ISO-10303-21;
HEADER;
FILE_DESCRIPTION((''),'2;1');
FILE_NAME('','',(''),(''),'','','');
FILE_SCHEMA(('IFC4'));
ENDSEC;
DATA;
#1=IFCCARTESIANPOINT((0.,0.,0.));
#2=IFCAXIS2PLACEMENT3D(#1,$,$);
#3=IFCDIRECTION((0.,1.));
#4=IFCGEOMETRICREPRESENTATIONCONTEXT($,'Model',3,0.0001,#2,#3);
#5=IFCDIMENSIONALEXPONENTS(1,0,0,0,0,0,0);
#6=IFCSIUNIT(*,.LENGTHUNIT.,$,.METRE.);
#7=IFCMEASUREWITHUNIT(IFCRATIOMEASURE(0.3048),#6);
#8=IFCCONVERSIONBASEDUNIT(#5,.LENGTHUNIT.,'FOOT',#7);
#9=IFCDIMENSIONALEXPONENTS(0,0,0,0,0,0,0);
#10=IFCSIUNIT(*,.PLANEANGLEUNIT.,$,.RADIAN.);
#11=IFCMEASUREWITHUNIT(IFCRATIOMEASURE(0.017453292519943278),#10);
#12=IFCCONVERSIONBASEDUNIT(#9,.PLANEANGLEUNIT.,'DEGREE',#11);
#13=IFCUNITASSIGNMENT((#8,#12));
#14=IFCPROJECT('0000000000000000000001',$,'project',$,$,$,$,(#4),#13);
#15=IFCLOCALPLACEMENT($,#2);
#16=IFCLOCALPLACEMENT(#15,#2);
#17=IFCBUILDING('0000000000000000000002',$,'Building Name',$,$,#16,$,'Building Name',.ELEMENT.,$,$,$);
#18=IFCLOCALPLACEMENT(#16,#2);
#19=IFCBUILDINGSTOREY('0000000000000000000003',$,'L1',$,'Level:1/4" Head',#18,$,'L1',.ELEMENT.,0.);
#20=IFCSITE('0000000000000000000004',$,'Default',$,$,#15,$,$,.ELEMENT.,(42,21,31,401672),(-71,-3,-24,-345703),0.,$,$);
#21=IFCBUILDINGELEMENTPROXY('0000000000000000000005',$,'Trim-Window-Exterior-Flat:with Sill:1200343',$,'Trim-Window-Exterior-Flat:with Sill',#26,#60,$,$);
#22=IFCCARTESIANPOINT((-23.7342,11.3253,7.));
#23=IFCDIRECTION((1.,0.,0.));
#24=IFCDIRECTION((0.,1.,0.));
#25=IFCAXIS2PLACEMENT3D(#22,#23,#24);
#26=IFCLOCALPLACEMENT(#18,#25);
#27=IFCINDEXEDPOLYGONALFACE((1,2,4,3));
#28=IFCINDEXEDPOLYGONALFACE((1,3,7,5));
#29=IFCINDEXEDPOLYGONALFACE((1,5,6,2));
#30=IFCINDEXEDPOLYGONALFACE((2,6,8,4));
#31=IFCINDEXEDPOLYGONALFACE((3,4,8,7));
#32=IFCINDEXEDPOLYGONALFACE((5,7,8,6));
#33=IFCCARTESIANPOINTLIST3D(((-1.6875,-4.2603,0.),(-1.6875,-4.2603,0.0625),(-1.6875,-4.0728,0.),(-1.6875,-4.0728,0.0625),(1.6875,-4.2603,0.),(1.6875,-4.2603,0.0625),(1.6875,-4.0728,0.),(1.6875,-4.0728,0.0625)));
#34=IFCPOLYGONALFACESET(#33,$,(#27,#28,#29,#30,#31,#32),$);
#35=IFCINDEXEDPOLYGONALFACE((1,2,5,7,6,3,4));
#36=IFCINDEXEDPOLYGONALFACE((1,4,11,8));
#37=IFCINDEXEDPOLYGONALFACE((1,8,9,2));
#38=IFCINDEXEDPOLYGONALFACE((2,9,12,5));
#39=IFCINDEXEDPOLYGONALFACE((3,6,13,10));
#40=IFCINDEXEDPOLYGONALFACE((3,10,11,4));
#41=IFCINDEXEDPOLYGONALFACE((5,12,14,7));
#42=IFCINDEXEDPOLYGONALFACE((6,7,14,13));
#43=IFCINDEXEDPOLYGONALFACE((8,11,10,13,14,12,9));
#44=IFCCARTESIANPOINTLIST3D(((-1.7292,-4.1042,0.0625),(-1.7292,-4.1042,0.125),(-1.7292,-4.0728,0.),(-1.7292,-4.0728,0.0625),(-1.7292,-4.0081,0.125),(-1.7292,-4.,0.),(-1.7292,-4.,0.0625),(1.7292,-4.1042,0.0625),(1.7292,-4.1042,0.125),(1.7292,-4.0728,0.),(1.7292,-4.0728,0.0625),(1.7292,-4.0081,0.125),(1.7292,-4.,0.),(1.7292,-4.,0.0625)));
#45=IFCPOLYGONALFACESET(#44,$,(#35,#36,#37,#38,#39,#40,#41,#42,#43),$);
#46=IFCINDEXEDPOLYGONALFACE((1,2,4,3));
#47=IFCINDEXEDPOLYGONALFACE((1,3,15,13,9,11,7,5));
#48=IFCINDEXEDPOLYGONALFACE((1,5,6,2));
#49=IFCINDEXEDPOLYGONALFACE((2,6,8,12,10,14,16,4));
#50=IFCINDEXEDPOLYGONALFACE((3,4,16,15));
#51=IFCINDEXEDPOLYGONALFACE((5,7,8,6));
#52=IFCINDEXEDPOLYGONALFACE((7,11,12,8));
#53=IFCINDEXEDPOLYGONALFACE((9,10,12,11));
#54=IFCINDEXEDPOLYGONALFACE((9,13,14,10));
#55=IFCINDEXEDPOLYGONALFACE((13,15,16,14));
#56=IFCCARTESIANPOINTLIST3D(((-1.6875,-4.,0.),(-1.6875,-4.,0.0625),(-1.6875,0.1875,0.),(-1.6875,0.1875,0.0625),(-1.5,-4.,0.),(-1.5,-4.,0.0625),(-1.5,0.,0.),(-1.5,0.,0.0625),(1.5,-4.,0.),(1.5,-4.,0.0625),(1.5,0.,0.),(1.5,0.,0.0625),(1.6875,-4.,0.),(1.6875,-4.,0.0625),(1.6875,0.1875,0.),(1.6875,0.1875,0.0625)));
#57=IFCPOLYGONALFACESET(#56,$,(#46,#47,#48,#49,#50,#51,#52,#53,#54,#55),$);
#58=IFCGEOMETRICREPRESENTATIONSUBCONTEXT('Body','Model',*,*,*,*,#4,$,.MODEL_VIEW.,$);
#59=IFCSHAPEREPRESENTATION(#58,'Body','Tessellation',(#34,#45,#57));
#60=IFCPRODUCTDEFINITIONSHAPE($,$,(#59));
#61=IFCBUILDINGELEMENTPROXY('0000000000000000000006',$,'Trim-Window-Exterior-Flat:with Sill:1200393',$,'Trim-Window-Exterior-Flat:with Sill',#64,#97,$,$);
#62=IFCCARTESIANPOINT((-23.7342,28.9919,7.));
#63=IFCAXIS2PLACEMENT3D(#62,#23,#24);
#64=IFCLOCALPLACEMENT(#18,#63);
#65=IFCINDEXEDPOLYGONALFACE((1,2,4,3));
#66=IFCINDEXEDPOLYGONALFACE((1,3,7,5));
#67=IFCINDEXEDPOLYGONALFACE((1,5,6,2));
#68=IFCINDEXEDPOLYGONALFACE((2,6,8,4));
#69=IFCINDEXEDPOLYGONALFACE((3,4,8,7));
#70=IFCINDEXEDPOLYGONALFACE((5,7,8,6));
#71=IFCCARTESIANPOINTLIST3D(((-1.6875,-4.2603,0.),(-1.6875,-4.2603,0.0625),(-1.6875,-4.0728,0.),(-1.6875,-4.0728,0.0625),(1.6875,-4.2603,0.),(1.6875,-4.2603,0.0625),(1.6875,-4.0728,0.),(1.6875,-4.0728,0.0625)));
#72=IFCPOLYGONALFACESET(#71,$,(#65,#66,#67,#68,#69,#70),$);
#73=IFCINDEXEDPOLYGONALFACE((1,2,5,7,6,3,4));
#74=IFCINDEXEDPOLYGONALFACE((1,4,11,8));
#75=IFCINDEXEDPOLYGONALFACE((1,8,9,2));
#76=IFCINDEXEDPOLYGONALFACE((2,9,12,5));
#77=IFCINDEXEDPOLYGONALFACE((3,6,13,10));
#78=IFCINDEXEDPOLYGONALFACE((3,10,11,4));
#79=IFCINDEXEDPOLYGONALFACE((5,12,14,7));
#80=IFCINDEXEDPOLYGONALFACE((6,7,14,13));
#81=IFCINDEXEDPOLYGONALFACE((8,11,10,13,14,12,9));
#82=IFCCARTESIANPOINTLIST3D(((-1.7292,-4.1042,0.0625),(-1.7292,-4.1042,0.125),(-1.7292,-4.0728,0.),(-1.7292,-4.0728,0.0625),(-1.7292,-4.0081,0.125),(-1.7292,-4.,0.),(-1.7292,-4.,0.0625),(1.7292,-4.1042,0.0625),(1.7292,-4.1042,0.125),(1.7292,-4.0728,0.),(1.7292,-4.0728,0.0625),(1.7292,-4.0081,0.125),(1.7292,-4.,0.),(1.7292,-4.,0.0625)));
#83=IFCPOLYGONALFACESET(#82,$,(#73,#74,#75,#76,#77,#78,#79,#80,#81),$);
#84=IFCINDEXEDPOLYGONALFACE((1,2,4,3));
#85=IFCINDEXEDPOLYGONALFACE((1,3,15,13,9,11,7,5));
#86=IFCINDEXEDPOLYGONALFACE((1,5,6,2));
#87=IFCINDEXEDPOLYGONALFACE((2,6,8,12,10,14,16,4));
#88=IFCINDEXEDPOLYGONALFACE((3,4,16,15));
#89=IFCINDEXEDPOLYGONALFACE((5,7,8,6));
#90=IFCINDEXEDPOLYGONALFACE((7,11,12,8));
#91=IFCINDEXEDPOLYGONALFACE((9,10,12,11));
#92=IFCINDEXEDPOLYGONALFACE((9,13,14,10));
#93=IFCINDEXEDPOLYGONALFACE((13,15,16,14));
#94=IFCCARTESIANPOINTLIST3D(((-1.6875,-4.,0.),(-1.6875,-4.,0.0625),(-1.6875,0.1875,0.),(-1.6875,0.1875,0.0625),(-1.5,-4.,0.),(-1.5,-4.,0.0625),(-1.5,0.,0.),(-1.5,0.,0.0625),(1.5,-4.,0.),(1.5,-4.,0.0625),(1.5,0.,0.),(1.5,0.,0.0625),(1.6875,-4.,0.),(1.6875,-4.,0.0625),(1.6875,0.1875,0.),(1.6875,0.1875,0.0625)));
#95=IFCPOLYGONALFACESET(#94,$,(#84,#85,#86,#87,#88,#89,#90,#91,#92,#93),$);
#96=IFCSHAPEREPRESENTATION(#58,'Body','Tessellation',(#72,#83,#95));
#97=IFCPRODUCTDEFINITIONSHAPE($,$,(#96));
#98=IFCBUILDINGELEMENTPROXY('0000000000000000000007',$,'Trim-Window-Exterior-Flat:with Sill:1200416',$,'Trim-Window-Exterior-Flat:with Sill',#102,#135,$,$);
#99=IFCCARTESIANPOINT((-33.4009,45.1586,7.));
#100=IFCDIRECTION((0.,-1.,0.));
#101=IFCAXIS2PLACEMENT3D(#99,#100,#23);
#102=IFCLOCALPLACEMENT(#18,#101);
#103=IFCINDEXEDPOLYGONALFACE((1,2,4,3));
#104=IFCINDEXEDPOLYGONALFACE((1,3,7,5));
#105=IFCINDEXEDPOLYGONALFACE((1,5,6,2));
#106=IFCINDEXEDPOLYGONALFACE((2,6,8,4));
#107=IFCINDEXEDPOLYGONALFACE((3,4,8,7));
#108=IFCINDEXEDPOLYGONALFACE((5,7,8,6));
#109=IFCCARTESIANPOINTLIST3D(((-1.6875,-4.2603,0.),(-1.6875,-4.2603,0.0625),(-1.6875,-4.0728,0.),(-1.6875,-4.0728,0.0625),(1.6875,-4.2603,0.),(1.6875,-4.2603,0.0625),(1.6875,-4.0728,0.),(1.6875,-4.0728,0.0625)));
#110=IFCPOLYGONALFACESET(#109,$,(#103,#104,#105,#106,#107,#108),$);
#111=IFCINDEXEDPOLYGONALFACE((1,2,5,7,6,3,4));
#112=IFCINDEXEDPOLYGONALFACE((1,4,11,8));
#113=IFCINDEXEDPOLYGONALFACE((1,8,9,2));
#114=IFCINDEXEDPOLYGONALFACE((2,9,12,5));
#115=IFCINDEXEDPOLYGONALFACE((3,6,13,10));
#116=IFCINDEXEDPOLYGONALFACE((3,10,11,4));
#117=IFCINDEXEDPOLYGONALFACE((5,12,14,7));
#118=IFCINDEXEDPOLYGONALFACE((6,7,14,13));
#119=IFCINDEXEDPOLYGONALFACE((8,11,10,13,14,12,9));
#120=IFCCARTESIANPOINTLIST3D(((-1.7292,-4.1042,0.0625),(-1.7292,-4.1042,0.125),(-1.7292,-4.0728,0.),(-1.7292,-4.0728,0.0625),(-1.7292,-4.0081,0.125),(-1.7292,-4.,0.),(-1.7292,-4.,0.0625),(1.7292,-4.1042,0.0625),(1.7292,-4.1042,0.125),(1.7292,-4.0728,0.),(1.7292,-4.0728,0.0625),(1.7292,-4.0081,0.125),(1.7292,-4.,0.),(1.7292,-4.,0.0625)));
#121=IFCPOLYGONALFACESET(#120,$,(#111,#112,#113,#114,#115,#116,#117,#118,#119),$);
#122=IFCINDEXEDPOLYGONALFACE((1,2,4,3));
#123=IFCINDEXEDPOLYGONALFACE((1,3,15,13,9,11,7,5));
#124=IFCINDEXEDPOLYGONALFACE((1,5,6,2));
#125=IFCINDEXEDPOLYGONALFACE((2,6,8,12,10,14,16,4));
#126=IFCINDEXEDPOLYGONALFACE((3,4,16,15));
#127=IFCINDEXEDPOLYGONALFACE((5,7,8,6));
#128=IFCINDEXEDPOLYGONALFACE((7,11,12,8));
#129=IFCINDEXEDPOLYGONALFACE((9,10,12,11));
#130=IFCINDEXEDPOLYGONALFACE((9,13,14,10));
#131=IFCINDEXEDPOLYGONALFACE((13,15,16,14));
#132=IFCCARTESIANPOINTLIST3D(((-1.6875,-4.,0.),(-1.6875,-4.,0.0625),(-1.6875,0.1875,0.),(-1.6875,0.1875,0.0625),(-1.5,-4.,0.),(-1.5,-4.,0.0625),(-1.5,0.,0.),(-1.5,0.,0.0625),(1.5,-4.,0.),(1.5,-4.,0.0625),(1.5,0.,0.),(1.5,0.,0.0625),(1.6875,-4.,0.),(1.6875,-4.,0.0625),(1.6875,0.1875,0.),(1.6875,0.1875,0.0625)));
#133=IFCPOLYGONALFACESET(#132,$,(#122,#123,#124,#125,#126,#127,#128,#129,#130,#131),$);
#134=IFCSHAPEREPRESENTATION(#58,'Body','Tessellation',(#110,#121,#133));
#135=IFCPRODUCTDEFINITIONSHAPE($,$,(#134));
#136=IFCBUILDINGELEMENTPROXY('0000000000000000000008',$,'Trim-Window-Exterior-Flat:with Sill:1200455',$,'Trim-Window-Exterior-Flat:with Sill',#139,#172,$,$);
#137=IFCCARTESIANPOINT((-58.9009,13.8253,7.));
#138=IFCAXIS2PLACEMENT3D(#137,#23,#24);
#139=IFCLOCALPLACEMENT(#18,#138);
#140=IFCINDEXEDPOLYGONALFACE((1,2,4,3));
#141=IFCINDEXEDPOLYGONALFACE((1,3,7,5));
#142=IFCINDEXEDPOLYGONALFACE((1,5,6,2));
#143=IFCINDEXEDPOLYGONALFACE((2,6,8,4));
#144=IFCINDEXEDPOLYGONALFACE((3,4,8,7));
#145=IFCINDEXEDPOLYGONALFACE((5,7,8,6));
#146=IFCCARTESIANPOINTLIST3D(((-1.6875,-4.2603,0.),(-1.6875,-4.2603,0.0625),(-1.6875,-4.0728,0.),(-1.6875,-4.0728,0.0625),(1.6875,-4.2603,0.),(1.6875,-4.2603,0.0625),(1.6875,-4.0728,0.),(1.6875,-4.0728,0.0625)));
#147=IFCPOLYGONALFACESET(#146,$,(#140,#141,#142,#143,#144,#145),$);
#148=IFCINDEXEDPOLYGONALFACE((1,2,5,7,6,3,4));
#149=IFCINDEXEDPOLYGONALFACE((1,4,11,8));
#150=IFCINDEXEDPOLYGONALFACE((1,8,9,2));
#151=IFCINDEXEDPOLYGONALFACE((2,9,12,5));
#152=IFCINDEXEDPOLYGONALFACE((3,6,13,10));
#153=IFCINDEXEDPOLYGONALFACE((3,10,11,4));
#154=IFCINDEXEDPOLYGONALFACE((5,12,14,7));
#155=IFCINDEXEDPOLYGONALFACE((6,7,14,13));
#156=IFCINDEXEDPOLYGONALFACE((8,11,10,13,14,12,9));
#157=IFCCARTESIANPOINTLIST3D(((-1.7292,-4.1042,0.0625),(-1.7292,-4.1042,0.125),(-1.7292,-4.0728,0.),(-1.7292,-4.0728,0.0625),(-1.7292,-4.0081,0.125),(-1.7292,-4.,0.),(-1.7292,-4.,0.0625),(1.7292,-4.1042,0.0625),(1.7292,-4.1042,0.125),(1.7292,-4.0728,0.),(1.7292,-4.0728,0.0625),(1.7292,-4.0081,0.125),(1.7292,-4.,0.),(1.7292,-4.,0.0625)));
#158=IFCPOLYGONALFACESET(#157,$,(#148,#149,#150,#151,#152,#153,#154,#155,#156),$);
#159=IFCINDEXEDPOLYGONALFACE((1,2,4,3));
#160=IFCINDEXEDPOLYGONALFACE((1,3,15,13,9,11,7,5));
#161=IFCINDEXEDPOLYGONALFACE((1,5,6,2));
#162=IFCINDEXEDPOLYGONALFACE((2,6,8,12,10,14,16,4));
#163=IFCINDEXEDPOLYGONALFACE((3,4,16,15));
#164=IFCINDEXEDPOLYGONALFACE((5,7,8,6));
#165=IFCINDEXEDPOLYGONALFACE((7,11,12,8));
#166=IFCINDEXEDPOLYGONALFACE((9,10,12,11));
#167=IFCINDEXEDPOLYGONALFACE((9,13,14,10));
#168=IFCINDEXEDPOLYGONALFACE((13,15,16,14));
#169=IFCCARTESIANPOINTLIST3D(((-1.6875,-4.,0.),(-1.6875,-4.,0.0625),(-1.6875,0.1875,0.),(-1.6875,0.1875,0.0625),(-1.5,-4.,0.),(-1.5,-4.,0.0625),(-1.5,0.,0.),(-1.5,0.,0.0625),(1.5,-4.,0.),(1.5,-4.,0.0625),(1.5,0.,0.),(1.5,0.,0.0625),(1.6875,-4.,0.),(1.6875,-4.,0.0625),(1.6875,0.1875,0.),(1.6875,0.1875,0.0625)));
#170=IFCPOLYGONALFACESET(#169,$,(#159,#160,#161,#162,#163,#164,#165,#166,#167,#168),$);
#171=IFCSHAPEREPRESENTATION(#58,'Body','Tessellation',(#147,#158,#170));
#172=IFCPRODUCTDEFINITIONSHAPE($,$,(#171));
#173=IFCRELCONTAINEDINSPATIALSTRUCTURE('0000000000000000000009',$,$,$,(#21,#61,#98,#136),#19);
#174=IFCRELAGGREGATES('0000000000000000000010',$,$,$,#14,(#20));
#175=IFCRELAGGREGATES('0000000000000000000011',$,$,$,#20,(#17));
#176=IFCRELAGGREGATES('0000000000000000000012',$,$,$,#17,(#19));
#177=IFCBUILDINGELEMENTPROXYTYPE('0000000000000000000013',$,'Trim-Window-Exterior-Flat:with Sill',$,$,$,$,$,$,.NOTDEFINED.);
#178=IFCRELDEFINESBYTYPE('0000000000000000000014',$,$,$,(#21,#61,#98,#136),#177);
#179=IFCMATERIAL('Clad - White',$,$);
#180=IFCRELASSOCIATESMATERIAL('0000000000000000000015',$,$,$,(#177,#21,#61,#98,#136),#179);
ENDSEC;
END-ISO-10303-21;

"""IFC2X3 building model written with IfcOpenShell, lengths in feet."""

from ifc_helpers import new_model, entity, si_unit, converted_unit, direction, frame, frame_2d, origin, place, context, subcontext, project, spatial, polyline, rectangle, outline, extrude, source, transform, mapped, material, type_object, type_shapes, element, save


model = new_model("IFC2X3")

# Units and contexts
model_context = context("Model", 3, precision=0.0001, world=origin(), true_north=direction((0.0, 1.0)))
body_context = subcontext(model_context, "Body", "Model", "MODEL_VIEW")
ifc_project = project(units=[converted_unit("LENGTHUNIT", "FOOT", entity("IfcRatioMeasure", 0.3048), si_unit("LENGTHUNIT", "METRE"), dimensions=[1, 0, 0, 0, 0, 0, 0]), converted_unit("PLANEANGLEUNIT", "DEGREE", entity("IfcRatioMeasure", 0.017453292519943278), si_unit("PLANEANGLEUNIT", "RADIAN"), dimensions=[0, 0, 0, 0, 0, 0, 0])], contexts=[model_context])

# Site, building, storey
site_placement = place(None, origin())
site = spatial("IfcSite", under=ifc_project, at=site_placement, Name="Default", CompositionType="ELEMENT", RefLatitude=(42, 21, 31, 401672), RefLongitude=(-71, -3, -24, -345703), RefElevation=0.0)
building_placement = place(site_placement, origin())
building = spatial("IfcBuilding", under=site, at=building_placement, Name="Building Name", LongName="Building Name", CompositionType="ELEMENT")
storey_placement = place(building_placement, origin())
storey = spatial("IfcBuildingStorey", under=building, at=storey_placement, Name="L1", ObjectType="Level:1/4\" Head", LongName="L1", CompositionType="ELEMENT", Elevation=0.0)

# Building element proxies
ifc_material_1 = material(Name="Clad - White")
building_element_proxy_type_1 = type_object("IfcBuildingElementProxyType", Name="Trim-Window-Exterior-Flat:with Sill", PredefinedType="NOTDEFINED", material=ifc_material_1)
shared_shape_1 = source(origin(), body_context, "Body", "SweptSolid", [
    extrude(rectangle(XDim=3.375, YDim=0.1875, at=frame_2d((0.0, 0.0), x_axis=(1.0, 0.0))), frame((0.0, -4.1665, 0.0), z_axis=(0.0, 0.0, 1.0), x_axis=(-1.0, 0.0, 0.0)), (0.0, 0.0, 1.0), 0.0625),
    extrude(outline(polyline([(-0.0625, -0.0525), (0.0, -0.0525), (0.0, -0.0211), (0.0625, -0.0211), (0.0625, 0.0517), (0.0, 0.0517), (-0.0625, 0.0436), (-0.0625, -0.0525)])), frame((-1.7292, -4.0517, 0.0625), z_axis=(1.0, 0.0, 0.0), x_axis=(0.0, 0.0, -1.0)), (0.0, 0.0, 1.0), 3.4583),
    extrude(outline(polyline([(-2.1406, -1.6875), (2.0469, -1.6875), (2.0469, -1.5), (-1.9531, -1.5), (-1.9531, 1.5), (2.0469, 1.5), (2.0469, 1.6875), (-2.1406, 1.6875), (-2.1406, -1.6875)])), frame((0.0, -1.9531, 0.0), z_axis=(0.0, 0.0, 1.0), x_axis=(0.0, -1.0, 0.0)), (0.0, 0.0, 1.0), 0.0625),
])
type_shapes(building_element_proxy_type_1, [shared_shape_1])
for number, where, z_axis, x_axis, name in (
    (1, (-23.7342, 11.3253, 7.0), (1.0, 0.0, 0.0), (0.0, 1.0, 0.0), "Trim-Window-Exterior-Flat:with Sill:1200343"),
    (2, (-23.7342, 28.9919, 7.0), (1.0, 0.0, 0.0), (0.0, 1.0, 0.0), "Trim-Window-Exterior-Flat:with Sill:1200393"),
    (3, (-33.4009, 45.1586, 7.0), (0.0, -1.0, 0.0), (1.0, 0.0, 0.0), "Trim-Window-Exterior-Flat:with Sill:1200416"),
    (4, (-58.9009, 13.8253, 7.0), (1.0, 0.0, 0.0), (0.0, 1.0, 0.0), "Trim-Window-Exterior-Flat:with Sill:1200455"),
):
    element("IfcBuildingElementProxy", number, at=place(storey_placement, frame(where, z_axis=z_axis, x_axis=x_axis)), inside=storey, type_object=building_element_proxy_type_1, material=ifc_material_1, Name=name, ObjectType="Trim-Window-Exterior-Flat:with Sill", context=body_context, shape_type="MappedRepresentation", body=[
        mapped(shared_shape_1, transform((0.0, 0.0, 0.0), scale=1.0)),
    ])

save(model, "model.ifc")
